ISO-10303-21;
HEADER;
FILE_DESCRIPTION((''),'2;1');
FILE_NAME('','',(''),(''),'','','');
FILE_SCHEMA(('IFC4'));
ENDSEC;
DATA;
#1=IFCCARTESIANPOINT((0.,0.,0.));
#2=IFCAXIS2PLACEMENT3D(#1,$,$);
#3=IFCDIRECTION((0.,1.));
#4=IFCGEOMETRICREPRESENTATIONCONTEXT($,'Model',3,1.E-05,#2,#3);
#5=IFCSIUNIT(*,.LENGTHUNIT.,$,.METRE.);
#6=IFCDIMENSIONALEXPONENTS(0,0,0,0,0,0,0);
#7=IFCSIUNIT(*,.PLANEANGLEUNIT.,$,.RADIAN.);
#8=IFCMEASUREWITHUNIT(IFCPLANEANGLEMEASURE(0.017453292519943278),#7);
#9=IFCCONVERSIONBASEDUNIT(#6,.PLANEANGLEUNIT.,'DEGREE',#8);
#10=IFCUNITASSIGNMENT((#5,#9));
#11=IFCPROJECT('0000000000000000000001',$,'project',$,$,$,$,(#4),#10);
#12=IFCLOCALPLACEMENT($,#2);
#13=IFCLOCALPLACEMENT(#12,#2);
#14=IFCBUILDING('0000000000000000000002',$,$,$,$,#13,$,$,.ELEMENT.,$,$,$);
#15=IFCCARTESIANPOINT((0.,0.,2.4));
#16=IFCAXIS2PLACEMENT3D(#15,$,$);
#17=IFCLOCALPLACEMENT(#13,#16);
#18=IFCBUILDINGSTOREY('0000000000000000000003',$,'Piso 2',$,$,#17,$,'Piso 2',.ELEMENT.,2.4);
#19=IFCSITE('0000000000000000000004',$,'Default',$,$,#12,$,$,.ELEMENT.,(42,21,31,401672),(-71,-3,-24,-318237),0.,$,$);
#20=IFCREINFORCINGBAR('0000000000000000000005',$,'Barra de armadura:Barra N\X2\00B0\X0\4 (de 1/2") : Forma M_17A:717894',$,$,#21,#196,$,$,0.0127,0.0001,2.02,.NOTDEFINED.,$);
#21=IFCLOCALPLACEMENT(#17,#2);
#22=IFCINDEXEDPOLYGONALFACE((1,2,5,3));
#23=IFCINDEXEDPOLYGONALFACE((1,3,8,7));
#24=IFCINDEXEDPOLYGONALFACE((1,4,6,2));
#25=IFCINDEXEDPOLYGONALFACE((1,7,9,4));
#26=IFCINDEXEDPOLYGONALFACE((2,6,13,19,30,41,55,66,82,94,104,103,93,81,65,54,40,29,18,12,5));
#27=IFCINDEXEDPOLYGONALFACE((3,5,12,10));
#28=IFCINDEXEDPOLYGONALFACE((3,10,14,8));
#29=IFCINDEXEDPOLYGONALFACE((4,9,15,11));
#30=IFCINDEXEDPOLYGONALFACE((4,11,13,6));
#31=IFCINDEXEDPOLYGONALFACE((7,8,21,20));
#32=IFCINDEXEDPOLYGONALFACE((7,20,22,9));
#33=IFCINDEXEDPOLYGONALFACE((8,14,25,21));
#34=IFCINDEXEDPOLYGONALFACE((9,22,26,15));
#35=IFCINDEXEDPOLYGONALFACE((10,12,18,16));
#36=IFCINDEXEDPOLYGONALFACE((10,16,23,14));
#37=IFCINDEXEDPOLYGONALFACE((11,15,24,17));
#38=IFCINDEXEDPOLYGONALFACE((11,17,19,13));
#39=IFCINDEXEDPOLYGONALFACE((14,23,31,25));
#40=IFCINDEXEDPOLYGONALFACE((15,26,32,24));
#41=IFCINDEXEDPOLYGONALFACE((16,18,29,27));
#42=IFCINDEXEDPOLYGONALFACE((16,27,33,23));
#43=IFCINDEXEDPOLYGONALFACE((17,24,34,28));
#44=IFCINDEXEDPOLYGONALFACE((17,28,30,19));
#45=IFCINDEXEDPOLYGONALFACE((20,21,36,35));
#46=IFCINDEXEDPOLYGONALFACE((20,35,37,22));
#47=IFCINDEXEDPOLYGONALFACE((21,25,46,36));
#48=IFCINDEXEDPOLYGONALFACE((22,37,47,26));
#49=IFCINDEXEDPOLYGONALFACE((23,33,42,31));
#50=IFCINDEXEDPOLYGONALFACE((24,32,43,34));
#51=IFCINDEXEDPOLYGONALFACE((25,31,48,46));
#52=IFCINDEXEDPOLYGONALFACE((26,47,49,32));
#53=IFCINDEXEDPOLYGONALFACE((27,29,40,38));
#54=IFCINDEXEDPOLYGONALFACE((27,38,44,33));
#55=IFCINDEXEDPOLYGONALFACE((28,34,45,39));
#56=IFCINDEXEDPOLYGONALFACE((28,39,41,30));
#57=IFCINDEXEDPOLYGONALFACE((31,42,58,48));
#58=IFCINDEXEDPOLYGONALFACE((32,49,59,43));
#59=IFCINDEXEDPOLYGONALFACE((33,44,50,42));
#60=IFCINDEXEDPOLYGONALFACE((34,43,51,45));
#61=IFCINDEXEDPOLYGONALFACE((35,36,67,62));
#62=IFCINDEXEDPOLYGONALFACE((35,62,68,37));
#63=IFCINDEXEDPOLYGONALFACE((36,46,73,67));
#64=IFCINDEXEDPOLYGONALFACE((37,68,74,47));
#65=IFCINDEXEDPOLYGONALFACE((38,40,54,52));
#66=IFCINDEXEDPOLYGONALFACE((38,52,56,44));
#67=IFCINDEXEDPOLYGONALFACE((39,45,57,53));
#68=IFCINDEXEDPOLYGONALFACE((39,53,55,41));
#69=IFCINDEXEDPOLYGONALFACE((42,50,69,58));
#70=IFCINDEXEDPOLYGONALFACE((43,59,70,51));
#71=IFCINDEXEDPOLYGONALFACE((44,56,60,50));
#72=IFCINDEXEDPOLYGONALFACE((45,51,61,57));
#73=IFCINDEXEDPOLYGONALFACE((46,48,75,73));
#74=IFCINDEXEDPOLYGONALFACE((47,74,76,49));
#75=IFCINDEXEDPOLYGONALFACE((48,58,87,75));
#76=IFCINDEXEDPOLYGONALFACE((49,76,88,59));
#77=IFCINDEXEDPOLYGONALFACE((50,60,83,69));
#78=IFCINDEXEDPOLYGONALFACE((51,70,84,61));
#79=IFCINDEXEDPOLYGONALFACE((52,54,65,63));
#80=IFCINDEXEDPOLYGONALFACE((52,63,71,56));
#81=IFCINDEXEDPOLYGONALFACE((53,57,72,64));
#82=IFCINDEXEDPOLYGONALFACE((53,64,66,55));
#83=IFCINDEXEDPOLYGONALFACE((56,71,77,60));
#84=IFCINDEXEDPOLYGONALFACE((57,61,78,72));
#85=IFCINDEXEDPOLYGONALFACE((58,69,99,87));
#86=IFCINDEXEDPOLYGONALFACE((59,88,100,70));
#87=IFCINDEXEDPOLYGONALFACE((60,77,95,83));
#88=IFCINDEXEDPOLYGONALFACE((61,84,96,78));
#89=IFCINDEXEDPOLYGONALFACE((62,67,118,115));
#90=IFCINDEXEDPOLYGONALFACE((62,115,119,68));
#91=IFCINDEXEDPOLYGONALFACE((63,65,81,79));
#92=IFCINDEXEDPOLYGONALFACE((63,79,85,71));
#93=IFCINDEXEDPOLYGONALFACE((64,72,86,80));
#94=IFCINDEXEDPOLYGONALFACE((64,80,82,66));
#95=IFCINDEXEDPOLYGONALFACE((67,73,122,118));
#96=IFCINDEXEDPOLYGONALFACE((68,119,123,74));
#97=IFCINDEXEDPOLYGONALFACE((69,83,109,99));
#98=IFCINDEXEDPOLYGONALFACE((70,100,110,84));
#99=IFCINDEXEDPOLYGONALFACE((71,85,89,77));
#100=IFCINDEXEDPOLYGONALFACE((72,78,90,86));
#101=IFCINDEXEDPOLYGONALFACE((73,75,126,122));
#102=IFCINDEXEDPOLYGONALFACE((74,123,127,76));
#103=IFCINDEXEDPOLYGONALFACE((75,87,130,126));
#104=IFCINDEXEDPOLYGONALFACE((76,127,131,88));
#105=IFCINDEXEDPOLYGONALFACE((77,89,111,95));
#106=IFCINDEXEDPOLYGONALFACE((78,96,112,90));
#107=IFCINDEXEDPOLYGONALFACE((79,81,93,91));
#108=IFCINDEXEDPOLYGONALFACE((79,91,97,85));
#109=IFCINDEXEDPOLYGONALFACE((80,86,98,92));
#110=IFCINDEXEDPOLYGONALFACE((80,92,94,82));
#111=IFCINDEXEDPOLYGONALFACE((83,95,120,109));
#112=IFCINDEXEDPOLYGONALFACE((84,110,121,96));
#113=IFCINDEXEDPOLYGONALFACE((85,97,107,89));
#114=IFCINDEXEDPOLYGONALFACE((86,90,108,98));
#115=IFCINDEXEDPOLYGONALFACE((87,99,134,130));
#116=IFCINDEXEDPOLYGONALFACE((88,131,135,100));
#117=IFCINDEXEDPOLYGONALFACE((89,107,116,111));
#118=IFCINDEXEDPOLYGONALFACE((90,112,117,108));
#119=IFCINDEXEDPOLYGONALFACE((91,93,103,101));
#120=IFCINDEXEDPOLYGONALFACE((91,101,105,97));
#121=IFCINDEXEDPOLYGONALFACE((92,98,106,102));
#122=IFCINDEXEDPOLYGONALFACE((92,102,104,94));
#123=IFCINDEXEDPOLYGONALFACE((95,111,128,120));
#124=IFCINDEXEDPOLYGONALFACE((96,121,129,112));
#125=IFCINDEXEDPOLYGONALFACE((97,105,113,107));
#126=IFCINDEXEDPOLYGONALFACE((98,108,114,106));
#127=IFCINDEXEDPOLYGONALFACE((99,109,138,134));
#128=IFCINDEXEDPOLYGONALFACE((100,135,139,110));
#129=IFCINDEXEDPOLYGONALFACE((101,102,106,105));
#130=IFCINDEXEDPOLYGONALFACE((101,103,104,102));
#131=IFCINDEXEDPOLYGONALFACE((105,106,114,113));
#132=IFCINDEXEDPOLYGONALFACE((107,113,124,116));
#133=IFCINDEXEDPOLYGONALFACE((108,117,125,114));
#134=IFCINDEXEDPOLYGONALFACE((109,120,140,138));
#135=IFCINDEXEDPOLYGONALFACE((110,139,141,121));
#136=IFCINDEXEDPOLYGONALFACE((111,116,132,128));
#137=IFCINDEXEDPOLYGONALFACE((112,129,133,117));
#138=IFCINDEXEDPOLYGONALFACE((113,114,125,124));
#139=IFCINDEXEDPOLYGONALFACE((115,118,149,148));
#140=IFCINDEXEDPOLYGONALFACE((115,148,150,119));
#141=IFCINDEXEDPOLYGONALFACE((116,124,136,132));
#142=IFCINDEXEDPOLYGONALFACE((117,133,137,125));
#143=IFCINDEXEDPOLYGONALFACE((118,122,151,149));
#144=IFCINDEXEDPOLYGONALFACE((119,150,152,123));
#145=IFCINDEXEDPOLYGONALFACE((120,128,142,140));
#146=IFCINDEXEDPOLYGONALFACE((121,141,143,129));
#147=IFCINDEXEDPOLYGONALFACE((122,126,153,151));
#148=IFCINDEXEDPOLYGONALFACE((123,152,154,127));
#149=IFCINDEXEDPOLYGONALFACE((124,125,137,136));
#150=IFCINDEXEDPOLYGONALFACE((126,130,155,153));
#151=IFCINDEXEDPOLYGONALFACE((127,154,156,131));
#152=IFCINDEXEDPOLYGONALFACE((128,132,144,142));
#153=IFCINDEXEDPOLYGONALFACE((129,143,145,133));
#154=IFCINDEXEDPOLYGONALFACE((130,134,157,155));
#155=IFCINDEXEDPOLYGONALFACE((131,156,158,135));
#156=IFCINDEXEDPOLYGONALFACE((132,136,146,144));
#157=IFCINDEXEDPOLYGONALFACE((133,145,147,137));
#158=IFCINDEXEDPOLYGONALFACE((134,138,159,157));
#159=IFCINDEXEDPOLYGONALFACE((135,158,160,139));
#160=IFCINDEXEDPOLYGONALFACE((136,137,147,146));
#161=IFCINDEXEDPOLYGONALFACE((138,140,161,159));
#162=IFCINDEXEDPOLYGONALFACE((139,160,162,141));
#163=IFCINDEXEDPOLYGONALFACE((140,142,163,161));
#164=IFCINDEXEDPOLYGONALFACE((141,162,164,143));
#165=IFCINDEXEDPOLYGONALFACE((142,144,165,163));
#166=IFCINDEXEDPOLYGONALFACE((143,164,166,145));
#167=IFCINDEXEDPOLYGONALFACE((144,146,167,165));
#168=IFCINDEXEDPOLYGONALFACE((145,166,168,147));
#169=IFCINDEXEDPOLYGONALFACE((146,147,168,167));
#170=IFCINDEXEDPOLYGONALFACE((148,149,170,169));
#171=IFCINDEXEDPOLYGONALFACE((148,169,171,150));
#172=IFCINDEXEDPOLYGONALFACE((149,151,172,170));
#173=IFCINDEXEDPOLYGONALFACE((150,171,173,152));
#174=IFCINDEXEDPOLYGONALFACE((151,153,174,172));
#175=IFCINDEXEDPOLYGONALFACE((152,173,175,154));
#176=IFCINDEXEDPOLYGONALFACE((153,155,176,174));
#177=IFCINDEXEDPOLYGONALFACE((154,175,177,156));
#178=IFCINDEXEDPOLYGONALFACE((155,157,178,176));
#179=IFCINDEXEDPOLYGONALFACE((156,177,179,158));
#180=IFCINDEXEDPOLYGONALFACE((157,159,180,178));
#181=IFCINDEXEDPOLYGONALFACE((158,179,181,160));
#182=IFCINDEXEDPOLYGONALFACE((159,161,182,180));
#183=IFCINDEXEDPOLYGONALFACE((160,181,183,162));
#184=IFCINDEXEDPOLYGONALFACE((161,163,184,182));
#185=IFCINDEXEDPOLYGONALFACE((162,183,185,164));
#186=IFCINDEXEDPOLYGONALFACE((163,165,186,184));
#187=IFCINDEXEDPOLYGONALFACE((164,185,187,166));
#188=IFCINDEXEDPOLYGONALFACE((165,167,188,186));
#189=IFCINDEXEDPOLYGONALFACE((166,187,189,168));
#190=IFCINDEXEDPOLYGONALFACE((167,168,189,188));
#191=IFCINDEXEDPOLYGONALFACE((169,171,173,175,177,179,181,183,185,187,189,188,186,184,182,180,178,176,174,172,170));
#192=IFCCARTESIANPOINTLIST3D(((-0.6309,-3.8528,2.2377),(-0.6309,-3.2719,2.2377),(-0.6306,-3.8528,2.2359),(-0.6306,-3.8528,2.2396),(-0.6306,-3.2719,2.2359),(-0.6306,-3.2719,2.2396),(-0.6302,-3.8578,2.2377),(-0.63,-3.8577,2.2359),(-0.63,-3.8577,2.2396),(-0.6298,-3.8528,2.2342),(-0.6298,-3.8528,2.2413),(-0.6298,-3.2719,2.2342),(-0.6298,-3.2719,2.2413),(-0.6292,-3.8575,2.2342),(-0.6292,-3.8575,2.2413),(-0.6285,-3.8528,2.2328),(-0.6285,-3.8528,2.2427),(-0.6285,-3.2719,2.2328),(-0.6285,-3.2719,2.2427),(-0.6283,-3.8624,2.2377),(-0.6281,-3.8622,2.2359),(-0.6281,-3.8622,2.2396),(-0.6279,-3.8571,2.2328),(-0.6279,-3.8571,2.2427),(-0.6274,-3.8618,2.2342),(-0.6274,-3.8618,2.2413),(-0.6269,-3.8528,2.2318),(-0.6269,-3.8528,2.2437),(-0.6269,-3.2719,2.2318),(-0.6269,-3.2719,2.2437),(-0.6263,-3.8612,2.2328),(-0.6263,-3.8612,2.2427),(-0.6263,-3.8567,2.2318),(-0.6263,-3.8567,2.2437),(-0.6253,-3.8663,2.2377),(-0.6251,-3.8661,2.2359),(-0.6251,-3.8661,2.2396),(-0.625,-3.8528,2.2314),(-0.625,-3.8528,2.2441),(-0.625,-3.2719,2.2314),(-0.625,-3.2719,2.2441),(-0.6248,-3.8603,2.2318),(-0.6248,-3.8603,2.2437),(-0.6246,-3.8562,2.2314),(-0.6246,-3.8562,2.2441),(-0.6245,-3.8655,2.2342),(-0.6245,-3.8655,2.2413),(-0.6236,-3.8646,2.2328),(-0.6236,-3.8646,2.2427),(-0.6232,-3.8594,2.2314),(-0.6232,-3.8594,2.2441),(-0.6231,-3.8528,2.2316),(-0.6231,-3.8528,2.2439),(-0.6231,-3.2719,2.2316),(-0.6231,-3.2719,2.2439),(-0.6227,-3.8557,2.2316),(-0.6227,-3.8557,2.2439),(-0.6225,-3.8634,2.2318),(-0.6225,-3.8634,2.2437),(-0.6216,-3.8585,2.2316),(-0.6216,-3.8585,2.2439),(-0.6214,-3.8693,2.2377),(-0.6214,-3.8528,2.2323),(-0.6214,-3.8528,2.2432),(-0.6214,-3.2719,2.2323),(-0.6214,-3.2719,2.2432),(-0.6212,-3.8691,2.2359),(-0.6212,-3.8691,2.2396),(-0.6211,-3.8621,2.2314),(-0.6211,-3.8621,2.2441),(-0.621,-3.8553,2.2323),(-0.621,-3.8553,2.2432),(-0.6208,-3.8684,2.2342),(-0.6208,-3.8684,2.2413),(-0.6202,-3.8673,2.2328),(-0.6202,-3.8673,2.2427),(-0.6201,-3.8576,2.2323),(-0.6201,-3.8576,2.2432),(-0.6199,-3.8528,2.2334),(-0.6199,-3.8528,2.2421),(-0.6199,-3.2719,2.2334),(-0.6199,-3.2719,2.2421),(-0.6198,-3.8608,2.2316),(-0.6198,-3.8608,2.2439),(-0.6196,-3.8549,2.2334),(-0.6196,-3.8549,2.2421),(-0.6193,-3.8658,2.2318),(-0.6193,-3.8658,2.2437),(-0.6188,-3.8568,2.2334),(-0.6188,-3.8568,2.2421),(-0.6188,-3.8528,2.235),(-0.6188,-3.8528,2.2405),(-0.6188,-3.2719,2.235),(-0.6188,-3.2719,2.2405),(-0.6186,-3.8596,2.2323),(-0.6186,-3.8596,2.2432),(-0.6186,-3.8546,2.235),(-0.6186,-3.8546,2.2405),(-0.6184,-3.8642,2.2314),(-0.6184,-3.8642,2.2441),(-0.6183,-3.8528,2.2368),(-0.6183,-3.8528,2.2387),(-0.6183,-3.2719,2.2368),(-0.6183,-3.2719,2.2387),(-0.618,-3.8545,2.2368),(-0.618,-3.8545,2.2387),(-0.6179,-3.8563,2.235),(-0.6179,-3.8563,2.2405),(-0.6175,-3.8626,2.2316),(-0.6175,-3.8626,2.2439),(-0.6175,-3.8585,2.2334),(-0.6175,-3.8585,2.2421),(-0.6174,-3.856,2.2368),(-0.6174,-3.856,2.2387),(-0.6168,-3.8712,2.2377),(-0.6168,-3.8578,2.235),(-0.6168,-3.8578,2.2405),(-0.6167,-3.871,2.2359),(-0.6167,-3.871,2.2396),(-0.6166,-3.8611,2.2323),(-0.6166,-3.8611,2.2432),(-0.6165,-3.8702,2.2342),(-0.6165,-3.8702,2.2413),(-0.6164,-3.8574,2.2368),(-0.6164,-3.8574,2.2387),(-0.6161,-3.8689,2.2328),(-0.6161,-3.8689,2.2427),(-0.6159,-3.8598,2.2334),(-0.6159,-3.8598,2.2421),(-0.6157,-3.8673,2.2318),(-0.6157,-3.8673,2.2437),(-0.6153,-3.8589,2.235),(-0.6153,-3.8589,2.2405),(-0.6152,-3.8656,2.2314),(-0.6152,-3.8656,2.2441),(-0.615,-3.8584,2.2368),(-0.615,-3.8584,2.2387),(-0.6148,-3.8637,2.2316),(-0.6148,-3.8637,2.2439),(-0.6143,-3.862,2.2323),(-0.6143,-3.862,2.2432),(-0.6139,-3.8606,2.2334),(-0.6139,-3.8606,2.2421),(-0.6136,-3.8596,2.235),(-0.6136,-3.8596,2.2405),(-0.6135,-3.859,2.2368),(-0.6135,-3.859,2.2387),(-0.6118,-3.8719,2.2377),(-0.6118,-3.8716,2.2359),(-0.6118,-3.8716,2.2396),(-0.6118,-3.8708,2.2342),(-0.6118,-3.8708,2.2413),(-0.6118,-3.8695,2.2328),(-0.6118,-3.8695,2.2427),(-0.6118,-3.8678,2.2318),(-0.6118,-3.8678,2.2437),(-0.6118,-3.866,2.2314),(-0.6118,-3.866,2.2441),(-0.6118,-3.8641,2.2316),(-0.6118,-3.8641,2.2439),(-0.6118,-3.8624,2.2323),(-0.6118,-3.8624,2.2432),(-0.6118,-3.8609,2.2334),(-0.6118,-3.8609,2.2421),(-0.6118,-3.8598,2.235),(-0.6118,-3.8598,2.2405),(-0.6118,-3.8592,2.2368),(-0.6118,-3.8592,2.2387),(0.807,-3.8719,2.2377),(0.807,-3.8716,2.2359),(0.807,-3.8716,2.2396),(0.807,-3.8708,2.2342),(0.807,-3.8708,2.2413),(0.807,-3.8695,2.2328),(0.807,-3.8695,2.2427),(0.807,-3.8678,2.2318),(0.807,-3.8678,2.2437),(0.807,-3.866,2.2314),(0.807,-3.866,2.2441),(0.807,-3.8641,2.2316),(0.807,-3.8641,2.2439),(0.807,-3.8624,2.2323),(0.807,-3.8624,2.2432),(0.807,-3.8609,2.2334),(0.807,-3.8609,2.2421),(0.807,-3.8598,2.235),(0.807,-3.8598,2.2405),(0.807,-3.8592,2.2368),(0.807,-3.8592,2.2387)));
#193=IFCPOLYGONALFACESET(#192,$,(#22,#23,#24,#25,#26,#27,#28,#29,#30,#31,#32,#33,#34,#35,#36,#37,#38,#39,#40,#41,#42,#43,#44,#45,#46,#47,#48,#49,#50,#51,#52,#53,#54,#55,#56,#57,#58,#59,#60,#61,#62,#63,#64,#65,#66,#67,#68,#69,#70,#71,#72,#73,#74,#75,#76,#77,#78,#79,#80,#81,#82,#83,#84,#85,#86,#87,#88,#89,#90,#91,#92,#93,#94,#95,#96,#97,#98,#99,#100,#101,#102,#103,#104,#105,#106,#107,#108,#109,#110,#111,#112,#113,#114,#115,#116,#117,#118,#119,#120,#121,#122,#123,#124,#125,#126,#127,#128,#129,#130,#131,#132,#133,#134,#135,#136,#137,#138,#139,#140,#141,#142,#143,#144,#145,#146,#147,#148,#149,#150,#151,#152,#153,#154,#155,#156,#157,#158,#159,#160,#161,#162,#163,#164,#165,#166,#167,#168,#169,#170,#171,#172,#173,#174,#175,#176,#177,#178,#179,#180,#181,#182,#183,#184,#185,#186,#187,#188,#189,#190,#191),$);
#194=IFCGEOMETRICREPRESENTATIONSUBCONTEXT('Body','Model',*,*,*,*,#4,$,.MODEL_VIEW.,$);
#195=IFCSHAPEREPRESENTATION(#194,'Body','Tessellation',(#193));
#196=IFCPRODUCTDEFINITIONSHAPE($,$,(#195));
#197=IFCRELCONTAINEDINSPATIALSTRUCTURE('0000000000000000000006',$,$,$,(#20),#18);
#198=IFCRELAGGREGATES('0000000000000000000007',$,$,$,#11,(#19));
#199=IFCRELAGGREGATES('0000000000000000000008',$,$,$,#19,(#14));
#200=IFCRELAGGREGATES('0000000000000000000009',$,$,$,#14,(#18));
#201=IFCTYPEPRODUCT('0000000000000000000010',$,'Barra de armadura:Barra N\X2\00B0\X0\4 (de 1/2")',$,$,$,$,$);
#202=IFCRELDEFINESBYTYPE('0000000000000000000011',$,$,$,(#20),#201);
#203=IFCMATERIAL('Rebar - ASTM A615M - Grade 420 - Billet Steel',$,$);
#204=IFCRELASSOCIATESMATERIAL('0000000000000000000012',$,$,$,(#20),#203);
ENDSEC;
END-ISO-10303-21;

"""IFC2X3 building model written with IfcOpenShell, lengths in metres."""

from ifc_helpers import new_model, entity, si_unit, converted_unit, direction, frame, origin, place, context, subcontext, project, spatial, material, type_object, element, save


model = new_model("IFC2X3")

# Units and contexts
model_context = context("Model", 3, precision=1e-05, world=origin(), true_north=direction((0.0, 1.0)))
body_context = subcontext(model_context, "Body", "Model", "MODEL_VIEW")
ifc_project = project(units=[si_unit("LENGTHUNIT", "METRE"), converted_unit("PLANEANGLEUNIT", "DEGREE", entity("IfcPlaneAngleMeasure", 0.017453292519943278), si_unit("PLANEANGLEUNIT", "RADIAN"), dimensions=[0, 0, 0, 0, 0, 0, 0])], contexts=[model_context])

# Site, building, storey
site_placement = place(None, origin())
site = spatial("IfcSite", under=ifc_project, at=site_placement, Name="Default", CompositionType="ELEMENT", RefLatitude=(42, 21, 31, 401672), RefLongitude=(-71, -3, -24, -318237), RefElevation=0.0)
building_placement = place(site_placement, origin())
building = spatial("IfcBuilding", under=site, at=building_placement, CompositionType="ELEMENT")
storey_placement = place(building_placement, frame((0.0, 0.0, 2.4)))
storey = spatial("IfcBuildingStorey", under=building, at=storey_placement, Name="Piso 2", LongName="Piso 2", CompositionType="ELEMENT", Elevation=2.4)

# Reinforcing bar
ifc_material_1 = material(Name="Rebar - ASTM A615M - Grade 420 - Billet Steel")
type_product_1 = type_object("IfcTypeProduct", Name="Barra de armadura:Barra N°4 (de 1/2\")")
reinforcing_bar_1_placement = place(storey_placement, origin())
element("IfcReinforcingBar", 1, at=reinforcing_bar_1_placement, inside=storey, type_object=type_product_1, material=ifc_material_1, Name="Barra de armadura:Barra N°4 (de 1/2\") : Forma M_17A:717894", BarLength=2.02, BarRole="NOTDEFINED", CrossSectionArea=0.0001, NominalDiameter=0.0127, context=body_context, shape_type="AdvancedSweptSolid", body=[
    entity("IfcSweptDiskSolid", entity("IfcCompositeCurve", [entity("IfcCompositeCurveSegment", "CONTINUOUS", True, entity("IfcPolyline", [entity("IfcCartesianPoint", [0.807, -3.8655, 2.2377]), entity("IfcCartesianPoint", [-0.6118, -3.8655, 2.2377])])), entity("IfcCompositeCurveSegment", "CONTINUOUS", True, entity("IfcTrimmedCurve", entity("IfcCircle", entity("IfcAxis2Placement3D", entity("IfcCartesianPoint", [-0.6118, -3.8528, 2.2377]), entity("IfcDirection", [0.0, 0.0, -1.0]), entity("IfcDirection", [-1.0, 0.0, 0.0])), 0.0127), [entity("IfcParameterValue", 270.0)], [entity("IfcParameterValue", 360.0)], True, "PARAMETER")), entity("IfcCompositeCurveSegment", "CONTINUOUS", True, entity("IfcPolyline", [entity("IfcCartesianPoint", [-0.6245, -3.8528, 2.2377]), entity("IfcCartesianPoint", [-0.6245, -3.2719, 2.2377])]))], False), 0.0063, None, 0.0, 92.0),
])

save(model, "model.ifc")
